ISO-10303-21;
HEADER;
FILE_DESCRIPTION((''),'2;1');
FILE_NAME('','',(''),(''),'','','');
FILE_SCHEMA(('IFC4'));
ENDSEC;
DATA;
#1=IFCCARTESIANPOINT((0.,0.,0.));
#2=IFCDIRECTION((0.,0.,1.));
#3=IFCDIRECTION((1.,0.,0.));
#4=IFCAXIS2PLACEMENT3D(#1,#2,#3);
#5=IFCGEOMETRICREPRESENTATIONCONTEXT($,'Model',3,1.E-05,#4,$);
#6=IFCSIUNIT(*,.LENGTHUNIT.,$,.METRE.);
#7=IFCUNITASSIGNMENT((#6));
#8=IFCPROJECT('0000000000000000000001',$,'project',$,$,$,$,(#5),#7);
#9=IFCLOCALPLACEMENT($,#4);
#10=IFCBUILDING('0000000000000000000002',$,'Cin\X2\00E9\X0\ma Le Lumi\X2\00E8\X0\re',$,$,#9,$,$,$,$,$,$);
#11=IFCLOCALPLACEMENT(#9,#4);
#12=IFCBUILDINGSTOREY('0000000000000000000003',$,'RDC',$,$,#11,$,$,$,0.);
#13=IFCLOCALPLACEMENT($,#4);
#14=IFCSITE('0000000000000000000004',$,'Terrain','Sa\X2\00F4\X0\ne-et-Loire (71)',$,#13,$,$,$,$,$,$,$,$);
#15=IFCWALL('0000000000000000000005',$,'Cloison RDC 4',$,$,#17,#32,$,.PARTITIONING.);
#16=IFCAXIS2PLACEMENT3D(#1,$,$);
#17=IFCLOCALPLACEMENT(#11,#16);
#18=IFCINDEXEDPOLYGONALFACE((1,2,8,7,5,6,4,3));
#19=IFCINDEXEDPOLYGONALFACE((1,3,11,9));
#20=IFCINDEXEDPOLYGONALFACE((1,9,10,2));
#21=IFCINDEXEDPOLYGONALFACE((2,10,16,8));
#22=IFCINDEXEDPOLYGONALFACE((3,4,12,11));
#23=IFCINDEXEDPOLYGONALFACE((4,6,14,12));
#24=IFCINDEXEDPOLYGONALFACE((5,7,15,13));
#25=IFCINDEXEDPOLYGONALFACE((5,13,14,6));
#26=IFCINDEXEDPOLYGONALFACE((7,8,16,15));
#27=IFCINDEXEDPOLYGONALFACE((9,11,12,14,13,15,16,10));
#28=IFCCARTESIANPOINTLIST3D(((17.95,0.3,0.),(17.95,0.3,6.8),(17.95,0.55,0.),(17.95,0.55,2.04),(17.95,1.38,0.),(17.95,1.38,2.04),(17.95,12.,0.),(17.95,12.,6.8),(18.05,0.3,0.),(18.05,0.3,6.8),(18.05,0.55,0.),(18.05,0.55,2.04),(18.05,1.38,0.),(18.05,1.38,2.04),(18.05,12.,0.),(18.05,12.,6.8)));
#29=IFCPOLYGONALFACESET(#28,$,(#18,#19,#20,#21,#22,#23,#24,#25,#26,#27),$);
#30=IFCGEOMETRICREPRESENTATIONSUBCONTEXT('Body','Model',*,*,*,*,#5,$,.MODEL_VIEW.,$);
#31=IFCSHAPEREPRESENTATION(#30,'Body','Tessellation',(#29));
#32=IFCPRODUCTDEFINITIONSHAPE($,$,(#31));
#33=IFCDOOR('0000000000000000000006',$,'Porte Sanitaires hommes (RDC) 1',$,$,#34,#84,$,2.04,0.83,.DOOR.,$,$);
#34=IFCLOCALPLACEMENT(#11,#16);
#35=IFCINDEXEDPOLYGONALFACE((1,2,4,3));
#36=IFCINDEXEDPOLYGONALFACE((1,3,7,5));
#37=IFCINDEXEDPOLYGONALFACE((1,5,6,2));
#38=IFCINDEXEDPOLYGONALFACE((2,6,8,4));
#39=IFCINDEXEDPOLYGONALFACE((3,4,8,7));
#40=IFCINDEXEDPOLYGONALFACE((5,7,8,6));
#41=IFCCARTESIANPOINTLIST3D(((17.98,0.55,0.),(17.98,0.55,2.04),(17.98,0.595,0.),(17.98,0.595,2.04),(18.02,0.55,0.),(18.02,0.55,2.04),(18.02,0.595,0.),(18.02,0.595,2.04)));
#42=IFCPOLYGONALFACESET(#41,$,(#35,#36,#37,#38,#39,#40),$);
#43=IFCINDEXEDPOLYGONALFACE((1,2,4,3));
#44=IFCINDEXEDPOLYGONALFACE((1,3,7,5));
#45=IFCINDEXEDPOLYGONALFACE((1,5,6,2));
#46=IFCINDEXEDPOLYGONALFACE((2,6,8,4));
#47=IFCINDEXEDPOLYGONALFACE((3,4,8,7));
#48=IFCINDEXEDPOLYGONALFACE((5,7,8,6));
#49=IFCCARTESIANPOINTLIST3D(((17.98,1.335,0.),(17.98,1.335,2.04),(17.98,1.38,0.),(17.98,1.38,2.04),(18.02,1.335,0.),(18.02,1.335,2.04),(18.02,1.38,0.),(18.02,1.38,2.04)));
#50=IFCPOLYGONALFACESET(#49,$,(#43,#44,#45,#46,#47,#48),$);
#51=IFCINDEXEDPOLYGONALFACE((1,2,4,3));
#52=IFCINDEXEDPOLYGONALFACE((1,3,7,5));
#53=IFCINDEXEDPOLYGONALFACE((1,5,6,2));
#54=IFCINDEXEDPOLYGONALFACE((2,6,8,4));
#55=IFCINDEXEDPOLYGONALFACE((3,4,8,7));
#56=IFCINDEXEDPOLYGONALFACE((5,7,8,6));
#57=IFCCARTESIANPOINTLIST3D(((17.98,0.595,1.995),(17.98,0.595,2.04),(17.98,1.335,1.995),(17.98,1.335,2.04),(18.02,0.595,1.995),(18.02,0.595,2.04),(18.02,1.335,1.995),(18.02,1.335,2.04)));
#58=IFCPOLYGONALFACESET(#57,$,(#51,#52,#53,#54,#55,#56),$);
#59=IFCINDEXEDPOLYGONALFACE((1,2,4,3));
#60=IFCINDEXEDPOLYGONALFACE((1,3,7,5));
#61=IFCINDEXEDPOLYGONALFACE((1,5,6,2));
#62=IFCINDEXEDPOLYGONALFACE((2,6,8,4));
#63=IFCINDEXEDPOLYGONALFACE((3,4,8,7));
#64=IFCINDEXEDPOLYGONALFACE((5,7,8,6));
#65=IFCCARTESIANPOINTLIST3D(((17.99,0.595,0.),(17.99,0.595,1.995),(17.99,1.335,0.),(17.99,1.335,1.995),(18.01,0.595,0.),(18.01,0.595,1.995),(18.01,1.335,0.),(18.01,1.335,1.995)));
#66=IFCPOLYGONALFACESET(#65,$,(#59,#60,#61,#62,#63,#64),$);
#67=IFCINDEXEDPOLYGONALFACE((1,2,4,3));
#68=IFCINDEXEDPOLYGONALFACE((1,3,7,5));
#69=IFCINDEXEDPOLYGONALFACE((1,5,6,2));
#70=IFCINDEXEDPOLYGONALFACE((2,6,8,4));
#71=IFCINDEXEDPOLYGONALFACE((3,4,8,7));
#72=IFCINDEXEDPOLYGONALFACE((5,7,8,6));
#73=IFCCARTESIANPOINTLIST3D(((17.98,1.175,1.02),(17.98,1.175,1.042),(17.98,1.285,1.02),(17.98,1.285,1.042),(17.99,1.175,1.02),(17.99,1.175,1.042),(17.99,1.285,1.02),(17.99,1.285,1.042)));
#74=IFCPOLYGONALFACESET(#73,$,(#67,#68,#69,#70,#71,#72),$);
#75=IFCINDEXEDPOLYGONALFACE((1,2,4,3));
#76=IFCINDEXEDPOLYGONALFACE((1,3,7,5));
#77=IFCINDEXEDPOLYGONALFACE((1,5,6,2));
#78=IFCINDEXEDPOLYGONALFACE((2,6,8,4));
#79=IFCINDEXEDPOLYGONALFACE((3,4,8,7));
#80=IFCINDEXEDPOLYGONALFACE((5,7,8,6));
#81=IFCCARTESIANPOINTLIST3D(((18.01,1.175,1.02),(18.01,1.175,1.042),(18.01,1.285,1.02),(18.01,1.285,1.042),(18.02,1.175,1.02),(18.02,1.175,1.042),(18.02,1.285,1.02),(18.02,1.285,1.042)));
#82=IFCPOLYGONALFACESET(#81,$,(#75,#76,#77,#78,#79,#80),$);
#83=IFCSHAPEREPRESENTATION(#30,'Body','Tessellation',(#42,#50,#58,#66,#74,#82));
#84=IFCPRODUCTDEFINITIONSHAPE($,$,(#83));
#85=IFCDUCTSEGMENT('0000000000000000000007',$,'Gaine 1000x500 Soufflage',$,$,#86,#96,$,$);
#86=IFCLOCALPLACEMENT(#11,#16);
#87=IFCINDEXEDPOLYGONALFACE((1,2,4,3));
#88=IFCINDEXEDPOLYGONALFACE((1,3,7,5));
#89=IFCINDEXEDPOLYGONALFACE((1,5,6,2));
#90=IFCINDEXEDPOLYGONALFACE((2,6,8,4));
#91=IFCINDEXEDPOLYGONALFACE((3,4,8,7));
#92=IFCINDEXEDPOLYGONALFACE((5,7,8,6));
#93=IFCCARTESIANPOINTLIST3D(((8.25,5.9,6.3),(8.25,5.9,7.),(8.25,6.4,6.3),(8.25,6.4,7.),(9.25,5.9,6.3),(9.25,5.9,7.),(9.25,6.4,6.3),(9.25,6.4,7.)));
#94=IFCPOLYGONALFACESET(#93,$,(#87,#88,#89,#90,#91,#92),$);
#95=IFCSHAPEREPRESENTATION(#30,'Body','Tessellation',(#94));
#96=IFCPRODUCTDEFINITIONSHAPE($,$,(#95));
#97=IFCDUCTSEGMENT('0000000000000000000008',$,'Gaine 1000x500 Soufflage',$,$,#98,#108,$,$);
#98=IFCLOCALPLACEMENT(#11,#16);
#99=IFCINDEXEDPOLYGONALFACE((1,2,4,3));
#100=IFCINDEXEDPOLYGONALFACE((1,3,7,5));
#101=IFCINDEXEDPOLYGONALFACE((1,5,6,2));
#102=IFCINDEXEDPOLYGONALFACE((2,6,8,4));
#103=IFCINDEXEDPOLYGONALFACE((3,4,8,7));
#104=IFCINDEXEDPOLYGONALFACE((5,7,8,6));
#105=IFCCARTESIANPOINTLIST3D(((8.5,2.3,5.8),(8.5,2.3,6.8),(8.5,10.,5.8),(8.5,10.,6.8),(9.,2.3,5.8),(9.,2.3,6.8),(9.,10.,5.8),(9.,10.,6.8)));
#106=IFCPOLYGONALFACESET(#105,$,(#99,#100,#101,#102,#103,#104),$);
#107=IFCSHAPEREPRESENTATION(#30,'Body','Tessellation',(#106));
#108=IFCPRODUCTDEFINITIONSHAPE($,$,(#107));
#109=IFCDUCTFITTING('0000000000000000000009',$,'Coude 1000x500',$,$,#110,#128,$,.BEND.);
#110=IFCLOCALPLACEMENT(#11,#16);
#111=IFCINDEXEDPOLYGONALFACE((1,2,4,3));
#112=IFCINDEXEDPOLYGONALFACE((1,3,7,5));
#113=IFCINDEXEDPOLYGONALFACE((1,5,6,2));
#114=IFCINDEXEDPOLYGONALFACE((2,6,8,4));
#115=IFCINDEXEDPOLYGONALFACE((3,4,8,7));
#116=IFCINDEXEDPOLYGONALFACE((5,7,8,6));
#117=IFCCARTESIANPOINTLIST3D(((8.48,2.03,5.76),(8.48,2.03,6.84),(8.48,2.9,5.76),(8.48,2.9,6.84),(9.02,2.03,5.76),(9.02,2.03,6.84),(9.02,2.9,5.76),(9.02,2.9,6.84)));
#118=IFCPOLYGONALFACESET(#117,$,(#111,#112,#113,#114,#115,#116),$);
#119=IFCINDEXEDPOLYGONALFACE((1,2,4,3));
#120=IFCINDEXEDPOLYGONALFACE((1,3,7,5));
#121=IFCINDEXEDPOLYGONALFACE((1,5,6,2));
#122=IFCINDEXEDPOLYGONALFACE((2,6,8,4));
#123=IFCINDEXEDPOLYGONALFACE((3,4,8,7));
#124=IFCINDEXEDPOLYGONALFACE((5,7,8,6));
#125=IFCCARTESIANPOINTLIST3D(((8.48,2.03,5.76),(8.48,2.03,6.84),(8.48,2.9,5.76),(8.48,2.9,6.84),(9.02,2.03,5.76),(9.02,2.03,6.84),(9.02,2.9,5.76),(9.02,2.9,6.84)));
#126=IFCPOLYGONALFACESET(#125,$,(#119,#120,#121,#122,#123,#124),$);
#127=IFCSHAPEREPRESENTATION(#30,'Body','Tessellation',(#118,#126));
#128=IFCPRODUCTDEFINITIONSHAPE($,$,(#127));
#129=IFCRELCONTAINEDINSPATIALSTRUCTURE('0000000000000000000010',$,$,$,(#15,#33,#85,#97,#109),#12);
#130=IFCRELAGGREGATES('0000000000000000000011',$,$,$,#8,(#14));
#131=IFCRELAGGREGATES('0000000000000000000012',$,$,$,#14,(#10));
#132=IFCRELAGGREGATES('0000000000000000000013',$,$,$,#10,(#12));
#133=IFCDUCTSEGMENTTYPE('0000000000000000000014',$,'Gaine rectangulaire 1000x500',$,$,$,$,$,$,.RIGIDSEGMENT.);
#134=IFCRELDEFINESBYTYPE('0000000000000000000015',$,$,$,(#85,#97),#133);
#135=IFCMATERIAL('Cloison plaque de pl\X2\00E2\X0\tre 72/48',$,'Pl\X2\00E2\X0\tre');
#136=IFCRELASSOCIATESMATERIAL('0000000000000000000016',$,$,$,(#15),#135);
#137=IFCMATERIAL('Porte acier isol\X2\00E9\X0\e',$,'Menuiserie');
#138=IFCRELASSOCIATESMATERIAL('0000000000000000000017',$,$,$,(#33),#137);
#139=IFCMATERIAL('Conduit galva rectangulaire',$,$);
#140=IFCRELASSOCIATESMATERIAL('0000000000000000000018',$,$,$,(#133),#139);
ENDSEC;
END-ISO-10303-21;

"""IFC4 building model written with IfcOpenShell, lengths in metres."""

from ifc_helpers import new_model, si_unit, frame, frame_2d, origin_with_axes, origin_2d, place, context, subcontext, project, spatial, rectangle, extrude, material, type_object, element, fill, save


model = new_model("IFC4")

# Units and contexts
model_context = context("Model", 3, precision=1e-05, world=origin_with_axes())
body_context = subcontext(model_context, "Body", "Model", "MODEL_VIEW")
ifc_project = project(units=[si_unit("LENGTHUNIT", "METRE")], contexts=[model_context])

# Site, building, storey
site_placement = place(None, origin_with_axes())
site = spatial("IfcSite", under=ifc_project, at=site_placement, Name="Terrain", Description="Saône-et-Loire (71)")
building_placement = place(None, origin_with_axes())
building = spatial("IfcBuilding", under=site, at=building_placement, Name="Cinéma Le Lumière")
storey_placement = place(building_placement, origin_with_axes())
storey = spatial("IfcBuildingStorey", under=building, at=storey_placement, Name="RDC", Elevation=0.0)

# Shared definitions
ifc_material_1 = material(Name="Porte acier isolée", Category="Menuiserie")

# Shared definitions
ifc_material_2 = material(Name="Cloison plaque de plâtre 72/48", Category="Plâtre")

# Wall, opening, door
wall_1_placement = place(storey_placement, frame((17.95, 0.3, 0.0), z_axis=(0.0, 0.0, 1.0), x_axis=(1.0, 0.0, 0.0)))
wall_1 = element("IfcWall", 1, at=wall_1_placement, inside=storey, material=ifc_material_2, Name="Cloison RDC 4", PredefinedType="PARTITIONING", context=body_context, shape_type="SweptSolid", body=[
    extrude(rectangle(XDim=0.1, YDim=11.7, at=frame_2d((0.05, 5.85))), origin_with_axes(), (0.0, 0.0, 1.0), 6.8),
])
opening_1_placement = place(storey_placement, frame((17.9, 0.55, 0.0), z_axis=(0.0, 0.0, 1.0), x_axis=(1.0, 0.0, 0.0)))
opening_1 = element("IfcOpeningElement", 2, at=opening_1_placement, cuts=wall_1, context=body_context, shape_type="SweptSolid", body=[
    extrude(rectangle(XDim=0.2, YDim=0.83, at=frame_2d((0.1, 0.415))), origin_with_axes(), (0.0, 0.0, 1.0), 2.04),
])
door_1_placement = place(storey_placement, frame((17.98, 0.55, 0.0), z_axis=(0.0, 0.0, 1.0), x_axis=(1.0, 0.0, 0.0)))
door_1 = element("IfcDoor", 3, at=door_1_placement, inside=storey, material=ifc_material_1, Name="Porte Sanitaires hommes (RDC) 1", OverallHeight=2.04, OverallWidth=0.83, PredefinedType="DOOR", context=body_context, shape_type="SweptSolid", body=[
    extrude(rectangle(XDim=0.04, YDim=0.045, at=frame_2d((0.02, 0.0225))), origin_with_axes(), (0.0, 0.0, 1.0), 2.04),
    extrude(rectangle(XDim=0.04, YDim=0.045, at=frame_2d((0.02, 0.0225))), frame((0.0, 0.785, 0.0), z_axis=(0.0, 0.0, 1.0), x_axis=(1.0, 0.0, 0.0)), (0.0, 0.0, 1.0), 2.04),
    extrude(rectangle(XDim=0.04, YDim=0.74, at=frame_2d((0.02, 0.37))), frame((0.0, 0.045, 1.995), z_axis=(0.0, 0.0, 1.0), x_axis=(1.0, 0.0, 0.0)), (0.0, 0.0, 1.0), 0.045),
    extrude(rectangle(XDim=0.02, YDim=0.74, at=frame_2d((0.01, 0.37))), frame((0.01, 0.045, 0.0), z_axis=(0.0, 0.0, 1.0), x_axis=(1.0, 0.0, 0.0)), (0.0, 0.0, 1.0), 1.995),
    extrude(rectangle(XDim=0.01, YDim=0.11, at=frame_2d((0.005, 0.055))), frame((0.0, 0.625, 1.02), z_axis=(0.0, 0.0, 1.0), x_axis=(1.0, 0.0, 0.0)), (0.0, 0.0, 1.0), 0.022),
    extrude(rectangle(XDim=0.01, YDim=0.11, at=frame_2d((0.005, 0.055))), frame((0.03, 0.625, 1.02), z_axis=(0.0, 0.0, 1.0), x_axis=(1.0, 0.0, 0.0)), (0.0, 0.0, 1.0), 0.022),
])
fill(opening_1, door_1)

# Duct segments
ifc_material_3 = material(Name="Conduit galva rectangulaire")
duct_segment_type = type_object("IfcDuctSegmentType", Name="Gaine rectangulaire 1000x500", PredefinedType="RIGIDSEGMENT", material=ifc_material_3)
duct_segment_1_placement = place(storey_placement, frame((8.75, 6.15, 7.0), z_axis=(0.0, 0.0, -1.0), x_axis=(1.0, 0.0, 0.0)))
element("IfcDuctSegment", 4, at=duct_segment_1_placement, inside=storey, type_object=duct_segment_type, Name="Gaine 1000x500 Soufflage", context=body_context, shape_type="SweptSolid", body=[
    extrude(rectangle(XDim=1.0, YDim=0.5, at=origin_2d()), origin_with_axes(), (0.0, 0.0, 1.0), 0.7),
])
duct_segment_2_placement = place(storey_placement, frame((8.75, 2.3, 6.3), z_axis=(0.0, 1.0, 0.0), x_axis=(0.0, 0.0, 1.0)))
element("IfcDuctSegment", 5, at=duct_segment_2_placement, inside=storey, type_object=duct_segment_type, Name="Gaine 1000x500 Soufflage", context=body_context, shape_type="SweptSolid", body=[
    extrude(rectangle(XDim=1.0, YDim=0.5, at=origin_2d()), origin_with_axes(), (0.0, 0.0, 1.0), 7.7),
])

# Duct fitting
duct_fitting_placement = place(storey_placement, frame((8.75, 2.3, 6.3), z_axis=(0.0, 0.0, 1.0), x_axis=(1.0, 0.0, 0.0)))
element("IfcDuctFitting", 6, at=duct_fitting_placement, inside=storey, Name="Coude 1000x500", PredefinedType="BEND", context=body_context, shape_type="SweptSolid", body=[
    extrude(rectangle(XDim=1.08, YDim=0.54, at=origin_2d()), frame((0.0, -0.27, 0.0), z_axis=(0.0, 1.0, 0.0), x_axis=(0.0, 0.0, 1.0)), (0.0, 0.0, 1.0), 0.87),
    extrude(rectangle(XDim=1.08, YDim=0.54, at=origin_2d()), frame((0.0, -0.27, 0.0), z_axis=(0.0, 1.0, 0.0), x_axis=(0.0, 0.0, 1.0)), (0.0, 0.0, 1.0), 0.87),
])

save(model, "model.ifc")
